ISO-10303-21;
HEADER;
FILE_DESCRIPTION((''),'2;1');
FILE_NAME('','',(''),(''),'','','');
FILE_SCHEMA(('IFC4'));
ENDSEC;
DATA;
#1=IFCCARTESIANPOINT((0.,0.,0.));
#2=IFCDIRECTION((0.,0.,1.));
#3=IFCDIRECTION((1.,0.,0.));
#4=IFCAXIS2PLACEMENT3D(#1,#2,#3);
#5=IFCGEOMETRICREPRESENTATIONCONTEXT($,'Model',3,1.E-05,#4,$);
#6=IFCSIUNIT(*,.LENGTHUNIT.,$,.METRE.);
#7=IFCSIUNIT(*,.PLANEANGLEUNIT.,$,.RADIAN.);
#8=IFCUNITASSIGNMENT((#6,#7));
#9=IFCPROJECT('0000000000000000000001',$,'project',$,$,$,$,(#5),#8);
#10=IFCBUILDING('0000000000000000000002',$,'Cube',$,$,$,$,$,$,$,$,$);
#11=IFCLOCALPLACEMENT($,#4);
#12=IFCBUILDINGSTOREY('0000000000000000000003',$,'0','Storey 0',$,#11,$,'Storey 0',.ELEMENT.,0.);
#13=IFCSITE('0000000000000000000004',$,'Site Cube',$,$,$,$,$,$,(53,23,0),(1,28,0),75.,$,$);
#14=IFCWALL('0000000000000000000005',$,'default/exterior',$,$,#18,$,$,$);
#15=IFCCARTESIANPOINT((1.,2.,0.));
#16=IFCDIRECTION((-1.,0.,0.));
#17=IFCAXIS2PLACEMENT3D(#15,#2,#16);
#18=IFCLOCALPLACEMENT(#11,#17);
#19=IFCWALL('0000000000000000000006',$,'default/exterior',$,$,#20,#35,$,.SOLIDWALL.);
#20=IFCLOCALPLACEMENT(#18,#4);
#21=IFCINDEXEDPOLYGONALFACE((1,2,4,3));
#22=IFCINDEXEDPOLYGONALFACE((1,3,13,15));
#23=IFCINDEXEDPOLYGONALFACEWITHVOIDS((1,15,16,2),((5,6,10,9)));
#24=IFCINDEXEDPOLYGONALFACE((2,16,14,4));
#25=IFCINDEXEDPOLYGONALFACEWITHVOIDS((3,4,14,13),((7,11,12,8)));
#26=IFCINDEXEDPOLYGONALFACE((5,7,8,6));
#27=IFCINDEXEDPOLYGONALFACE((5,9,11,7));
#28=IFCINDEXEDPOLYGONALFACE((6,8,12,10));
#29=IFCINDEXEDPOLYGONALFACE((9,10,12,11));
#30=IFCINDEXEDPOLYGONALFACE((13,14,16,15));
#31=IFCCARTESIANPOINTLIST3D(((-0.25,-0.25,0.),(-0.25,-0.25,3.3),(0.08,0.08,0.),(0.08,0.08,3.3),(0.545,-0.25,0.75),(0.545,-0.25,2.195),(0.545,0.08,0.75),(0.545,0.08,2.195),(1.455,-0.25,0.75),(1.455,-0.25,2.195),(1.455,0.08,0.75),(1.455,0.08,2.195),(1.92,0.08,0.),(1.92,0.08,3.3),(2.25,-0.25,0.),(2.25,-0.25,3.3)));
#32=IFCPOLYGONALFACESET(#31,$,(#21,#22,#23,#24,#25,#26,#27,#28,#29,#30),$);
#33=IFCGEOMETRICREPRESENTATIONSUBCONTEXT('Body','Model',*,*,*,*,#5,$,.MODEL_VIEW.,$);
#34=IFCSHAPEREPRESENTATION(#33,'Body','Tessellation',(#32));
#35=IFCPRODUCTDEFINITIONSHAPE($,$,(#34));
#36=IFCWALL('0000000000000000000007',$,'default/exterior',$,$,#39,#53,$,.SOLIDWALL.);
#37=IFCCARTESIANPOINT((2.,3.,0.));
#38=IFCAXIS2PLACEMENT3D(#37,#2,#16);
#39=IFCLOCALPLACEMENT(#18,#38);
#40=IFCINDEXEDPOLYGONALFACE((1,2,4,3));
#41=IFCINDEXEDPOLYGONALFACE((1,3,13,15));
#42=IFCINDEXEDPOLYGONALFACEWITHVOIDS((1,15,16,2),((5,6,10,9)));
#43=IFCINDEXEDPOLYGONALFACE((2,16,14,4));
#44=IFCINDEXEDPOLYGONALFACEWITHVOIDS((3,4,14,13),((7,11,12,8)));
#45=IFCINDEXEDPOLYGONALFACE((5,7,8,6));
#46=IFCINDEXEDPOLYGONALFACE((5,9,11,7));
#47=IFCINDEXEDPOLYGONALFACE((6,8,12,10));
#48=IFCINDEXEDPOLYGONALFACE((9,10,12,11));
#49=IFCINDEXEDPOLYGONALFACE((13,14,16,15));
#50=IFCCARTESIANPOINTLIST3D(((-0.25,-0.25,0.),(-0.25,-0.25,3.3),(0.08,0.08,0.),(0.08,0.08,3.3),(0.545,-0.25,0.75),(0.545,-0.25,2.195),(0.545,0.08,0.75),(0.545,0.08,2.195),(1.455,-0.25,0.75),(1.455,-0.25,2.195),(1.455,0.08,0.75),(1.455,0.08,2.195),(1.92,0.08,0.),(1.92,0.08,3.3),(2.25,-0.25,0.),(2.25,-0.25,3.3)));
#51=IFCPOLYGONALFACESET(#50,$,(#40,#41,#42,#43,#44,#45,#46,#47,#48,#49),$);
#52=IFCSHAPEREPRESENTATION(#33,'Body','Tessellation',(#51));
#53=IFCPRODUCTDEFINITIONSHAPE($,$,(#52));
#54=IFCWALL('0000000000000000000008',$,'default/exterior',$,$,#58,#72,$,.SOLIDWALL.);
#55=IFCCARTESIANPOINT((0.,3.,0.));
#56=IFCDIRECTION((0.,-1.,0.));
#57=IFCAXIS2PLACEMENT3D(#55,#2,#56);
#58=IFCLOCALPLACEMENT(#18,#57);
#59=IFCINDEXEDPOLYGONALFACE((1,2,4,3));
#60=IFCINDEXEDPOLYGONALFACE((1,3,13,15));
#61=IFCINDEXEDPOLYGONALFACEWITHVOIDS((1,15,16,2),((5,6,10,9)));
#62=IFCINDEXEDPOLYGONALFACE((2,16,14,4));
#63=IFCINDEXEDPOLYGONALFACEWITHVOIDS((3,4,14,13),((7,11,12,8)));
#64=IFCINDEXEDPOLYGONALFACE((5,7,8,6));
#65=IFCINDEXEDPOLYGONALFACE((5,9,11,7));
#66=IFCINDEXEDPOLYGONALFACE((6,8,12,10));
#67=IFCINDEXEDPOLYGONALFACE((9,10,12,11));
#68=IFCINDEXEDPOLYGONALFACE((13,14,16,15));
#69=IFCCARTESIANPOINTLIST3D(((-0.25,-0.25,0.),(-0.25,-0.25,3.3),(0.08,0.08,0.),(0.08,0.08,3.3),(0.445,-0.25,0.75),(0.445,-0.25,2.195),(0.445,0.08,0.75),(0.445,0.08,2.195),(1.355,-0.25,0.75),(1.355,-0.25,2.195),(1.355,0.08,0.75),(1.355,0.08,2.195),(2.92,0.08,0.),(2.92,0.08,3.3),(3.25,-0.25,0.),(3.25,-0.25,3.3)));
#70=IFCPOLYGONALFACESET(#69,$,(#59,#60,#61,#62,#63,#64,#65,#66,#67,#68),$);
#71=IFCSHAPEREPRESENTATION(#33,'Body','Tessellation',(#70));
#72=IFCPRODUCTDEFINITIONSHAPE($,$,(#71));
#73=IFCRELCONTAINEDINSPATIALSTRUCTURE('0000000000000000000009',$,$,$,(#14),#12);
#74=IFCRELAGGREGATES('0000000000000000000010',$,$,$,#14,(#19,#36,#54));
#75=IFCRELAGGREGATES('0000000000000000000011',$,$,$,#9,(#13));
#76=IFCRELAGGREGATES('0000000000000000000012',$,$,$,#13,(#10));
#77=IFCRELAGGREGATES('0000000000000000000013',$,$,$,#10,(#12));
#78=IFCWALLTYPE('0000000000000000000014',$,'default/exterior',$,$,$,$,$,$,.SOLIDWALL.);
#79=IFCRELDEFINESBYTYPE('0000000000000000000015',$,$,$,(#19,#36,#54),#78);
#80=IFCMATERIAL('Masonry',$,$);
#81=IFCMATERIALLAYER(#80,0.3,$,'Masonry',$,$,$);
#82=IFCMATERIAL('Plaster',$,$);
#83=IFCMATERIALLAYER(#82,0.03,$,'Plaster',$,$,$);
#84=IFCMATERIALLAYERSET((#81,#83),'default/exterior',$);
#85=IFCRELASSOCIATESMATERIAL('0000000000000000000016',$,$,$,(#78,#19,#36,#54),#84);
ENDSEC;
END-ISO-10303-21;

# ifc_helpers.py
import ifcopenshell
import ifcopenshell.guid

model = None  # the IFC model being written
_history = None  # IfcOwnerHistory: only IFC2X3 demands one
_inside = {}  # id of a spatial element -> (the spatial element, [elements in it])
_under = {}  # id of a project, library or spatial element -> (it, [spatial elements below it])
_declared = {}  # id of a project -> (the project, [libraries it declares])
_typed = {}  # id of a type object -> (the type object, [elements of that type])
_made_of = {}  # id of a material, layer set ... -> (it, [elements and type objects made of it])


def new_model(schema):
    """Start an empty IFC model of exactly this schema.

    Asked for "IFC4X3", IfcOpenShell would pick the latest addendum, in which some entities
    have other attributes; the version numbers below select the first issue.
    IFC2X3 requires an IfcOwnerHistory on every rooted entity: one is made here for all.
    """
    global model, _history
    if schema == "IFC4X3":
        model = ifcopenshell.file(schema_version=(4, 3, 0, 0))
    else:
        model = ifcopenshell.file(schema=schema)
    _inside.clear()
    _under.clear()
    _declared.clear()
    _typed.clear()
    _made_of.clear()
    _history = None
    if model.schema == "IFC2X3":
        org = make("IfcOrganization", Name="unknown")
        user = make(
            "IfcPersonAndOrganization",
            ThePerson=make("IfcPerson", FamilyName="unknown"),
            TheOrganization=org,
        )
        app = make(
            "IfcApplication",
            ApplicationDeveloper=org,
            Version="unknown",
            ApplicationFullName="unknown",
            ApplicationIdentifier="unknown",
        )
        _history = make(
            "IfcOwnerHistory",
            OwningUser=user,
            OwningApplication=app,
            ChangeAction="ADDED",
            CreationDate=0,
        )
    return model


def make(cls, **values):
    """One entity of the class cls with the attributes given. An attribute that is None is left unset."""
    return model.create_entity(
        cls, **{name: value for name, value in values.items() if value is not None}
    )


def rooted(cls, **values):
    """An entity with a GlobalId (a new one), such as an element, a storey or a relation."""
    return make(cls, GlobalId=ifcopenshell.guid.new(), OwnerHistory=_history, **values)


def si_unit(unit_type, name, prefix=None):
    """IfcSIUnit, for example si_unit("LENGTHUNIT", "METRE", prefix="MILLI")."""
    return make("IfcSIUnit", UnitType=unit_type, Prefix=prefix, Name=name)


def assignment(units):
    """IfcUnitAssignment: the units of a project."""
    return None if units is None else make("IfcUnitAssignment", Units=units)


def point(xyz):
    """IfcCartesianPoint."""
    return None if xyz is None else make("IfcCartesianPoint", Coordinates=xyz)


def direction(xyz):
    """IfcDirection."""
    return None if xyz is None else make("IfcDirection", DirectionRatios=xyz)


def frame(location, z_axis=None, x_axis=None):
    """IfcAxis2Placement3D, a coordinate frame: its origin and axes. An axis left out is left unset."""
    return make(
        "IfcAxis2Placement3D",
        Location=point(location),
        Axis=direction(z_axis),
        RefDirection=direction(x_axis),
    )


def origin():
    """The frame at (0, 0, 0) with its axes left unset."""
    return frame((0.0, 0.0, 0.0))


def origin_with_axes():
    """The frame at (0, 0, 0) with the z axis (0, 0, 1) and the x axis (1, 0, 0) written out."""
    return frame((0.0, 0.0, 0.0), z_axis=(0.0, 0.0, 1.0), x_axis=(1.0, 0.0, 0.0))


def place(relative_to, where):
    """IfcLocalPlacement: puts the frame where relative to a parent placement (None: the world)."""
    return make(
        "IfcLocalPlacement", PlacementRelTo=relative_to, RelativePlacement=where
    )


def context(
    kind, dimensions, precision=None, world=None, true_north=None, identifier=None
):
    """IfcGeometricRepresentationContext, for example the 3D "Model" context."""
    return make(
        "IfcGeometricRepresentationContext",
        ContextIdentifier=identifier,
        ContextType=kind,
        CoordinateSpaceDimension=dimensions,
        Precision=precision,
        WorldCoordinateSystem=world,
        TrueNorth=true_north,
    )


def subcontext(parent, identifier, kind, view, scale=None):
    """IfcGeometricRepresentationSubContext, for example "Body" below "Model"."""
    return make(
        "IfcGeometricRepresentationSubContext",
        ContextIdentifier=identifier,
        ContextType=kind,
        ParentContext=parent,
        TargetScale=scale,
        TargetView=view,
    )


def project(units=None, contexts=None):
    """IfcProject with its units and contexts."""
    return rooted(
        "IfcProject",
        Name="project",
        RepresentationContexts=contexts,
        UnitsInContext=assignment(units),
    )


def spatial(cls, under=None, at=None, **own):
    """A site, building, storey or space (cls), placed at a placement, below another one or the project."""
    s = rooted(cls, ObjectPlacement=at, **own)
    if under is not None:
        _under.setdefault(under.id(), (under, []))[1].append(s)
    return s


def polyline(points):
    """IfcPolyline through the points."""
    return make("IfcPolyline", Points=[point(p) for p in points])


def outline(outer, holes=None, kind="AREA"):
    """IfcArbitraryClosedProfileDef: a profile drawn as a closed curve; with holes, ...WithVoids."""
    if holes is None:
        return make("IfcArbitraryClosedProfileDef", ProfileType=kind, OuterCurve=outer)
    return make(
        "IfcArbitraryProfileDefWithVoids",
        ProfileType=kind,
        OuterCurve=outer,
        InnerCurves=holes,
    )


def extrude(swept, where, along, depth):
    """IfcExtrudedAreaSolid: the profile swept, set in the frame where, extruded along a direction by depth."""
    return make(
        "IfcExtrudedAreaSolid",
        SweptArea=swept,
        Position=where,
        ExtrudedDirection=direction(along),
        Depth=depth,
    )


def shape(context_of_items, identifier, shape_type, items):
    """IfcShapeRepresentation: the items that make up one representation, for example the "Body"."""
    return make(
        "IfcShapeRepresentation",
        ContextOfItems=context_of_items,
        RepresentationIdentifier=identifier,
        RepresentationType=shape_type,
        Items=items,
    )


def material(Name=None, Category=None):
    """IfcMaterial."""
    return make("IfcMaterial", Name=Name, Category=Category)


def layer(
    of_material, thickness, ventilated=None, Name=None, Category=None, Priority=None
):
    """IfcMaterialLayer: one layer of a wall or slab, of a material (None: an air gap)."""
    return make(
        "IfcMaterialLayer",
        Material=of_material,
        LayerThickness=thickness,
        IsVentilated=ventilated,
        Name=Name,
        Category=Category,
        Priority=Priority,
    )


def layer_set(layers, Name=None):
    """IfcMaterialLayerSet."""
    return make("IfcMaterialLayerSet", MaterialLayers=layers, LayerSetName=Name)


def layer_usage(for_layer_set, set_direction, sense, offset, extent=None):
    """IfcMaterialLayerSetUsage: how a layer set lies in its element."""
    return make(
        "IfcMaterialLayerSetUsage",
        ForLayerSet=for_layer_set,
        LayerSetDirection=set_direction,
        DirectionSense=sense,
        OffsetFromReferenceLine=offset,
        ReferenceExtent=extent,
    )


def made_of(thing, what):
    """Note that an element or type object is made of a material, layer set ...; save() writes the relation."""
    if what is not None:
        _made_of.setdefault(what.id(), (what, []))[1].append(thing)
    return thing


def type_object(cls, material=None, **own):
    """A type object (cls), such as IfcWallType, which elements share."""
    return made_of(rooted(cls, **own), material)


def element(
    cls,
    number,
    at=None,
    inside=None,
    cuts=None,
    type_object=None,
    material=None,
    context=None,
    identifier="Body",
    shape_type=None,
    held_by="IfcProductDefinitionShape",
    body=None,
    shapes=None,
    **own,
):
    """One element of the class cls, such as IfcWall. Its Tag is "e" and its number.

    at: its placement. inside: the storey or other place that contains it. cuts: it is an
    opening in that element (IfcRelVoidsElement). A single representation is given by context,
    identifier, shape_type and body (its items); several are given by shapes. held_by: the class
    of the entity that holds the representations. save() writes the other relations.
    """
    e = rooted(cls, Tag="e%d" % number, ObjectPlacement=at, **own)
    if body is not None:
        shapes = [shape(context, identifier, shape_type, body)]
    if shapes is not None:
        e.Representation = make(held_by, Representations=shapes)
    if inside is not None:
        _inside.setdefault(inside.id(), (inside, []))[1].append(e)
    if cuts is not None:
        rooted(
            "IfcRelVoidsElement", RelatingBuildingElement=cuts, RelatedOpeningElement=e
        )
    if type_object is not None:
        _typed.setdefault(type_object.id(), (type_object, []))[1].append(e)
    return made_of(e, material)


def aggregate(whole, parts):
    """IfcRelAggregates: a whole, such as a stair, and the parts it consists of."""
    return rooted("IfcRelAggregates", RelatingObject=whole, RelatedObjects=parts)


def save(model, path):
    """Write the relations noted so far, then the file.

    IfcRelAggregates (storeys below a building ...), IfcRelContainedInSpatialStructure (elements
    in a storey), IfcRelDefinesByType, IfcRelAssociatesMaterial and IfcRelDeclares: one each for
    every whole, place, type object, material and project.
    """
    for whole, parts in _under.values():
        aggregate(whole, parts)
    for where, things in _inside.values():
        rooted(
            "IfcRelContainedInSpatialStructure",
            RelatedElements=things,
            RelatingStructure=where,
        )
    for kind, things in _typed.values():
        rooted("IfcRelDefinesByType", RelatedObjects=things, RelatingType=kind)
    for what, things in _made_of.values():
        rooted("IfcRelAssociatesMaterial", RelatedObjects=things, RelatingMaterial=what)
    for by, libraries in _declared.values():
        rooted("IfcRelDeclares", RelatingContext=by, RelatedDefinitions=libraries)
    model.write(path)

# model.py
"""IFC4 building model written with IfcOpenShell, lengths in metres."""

from ifc_helpers import new_model, si_unit, frame, origin, origin_with_axes, place, context, subcontext, project, spatial, polyline, outline, extrude, material, layer, layer_set, layer_usage, type_object, element, aggregate, save


model = new_model("IFC4")

# Units and contexts
model_context = context("Model", 3, precision=1e-05, world=origin_with_axes())
body_context = subcontext(model_context, "Body", "Model", "MODEL_VIEW")
ifc_project = project(units=[si_unit("LENGTHUNIT", "METRE"), si_unit("PLANEANGLEUNIT", "RADIAN")], contexts=[model_context])

# Site, building, storey
site = spatial("IfcSite", under=ifc_project, Name="Site Cube", RefLatitude=(53, 23, 0), RefLongitude=(1, 28, 0), RefElevation=75.0)
building = spatial("IfcBuilding", under=site, Name="Cube")
storey_placement = place(None, origin_with_axes())
storey = spatial("IfcBuildingStorey", under=building, at=storey_placement, Name="0", Description="Storey 0", LongName="Storey 0", CompositionType="ELEMENT", Elevation=0.0)

# Walls, openings
wall_1_placement = place(storey_placement, frame((1.0, 2.0, 0.0), z_axis=(0.0, 0.0, 1.0), x_axis=(-1.0, 0.0, 0.0)))
wall_1 = element("IfcWall", 1, at=wall_1_placement, inside=storey, Name="default/exterior")
ifc_material_1 = material(Name="Masonry")
ifc_layer_1 = layer(ifc_material_1, 0.3, Name="Masonry")
ifc_material_2 = material(Name="Plaster")
ifc_layer_2 = layer(ifc_material_2, 0.03, Name="Plaster")
ifc_layer_set_1 = layer_set([ifc_layer_1, ifc_layer_2], Name="default/exterior")
ifc_layer_usage_1 = layer_usage(ifc_layer_set_1, "AXIS2", "POSITIVE", -0.25)
wall_type = type_object("IfcWallType", Name="default/exterior", PredefinedType="SOLIDWALL", material=ifc_layer_set_1)
wall_2_placement = place(wall_1_placement, origin_with_axes())
wall_2 = element("IfcWall", 2, at=wall_2_placement, type_object=wall_type, material=ifc_layer_usage_1, Name="default/exterior", PredefinedType="SOLIDWALL", context=body_context, shape_type="SweptSolid", body=[
    extrude(outline(polyline([(0.08, 0.08), (-0.25, -0.25), (2.25, -0.25), (1.92, 0.08), (0.08, 0.08)])), origin(), (0.0, 0.0, 1.0), 3.3),
])
opening_1_placement = place(None, frame((0.455, 2.25, 0.75), z_axis=(0.0, 0.0, 1.0), x_axis=(-1.0, 0.0, 0.0)))
element("IfcOpeningElement", 3, at=opening_1_placement, cuts=wall_2, PredefinedType="OPENING", context=body_context, shape_type="SweptSolid", body=[
    extrude(outline(polyline([(0.0, -0.02), (0.91, -0.02), (0.91, 0.35), (0.0, 0.35), (0.0, -0.02)])), origin(), (0.0, 0.0, 1.0), 1.445),
])
ifc_layer_usage_2 = layer_usage(ifc_layer_set_1, "AXIS2", "POSITIVE", -0.25)
wall_3_placement = place(wall_1_placement, frame((2.0, 3.0, 0.0), z_axis=(0.0, 0.0, 1.0), x_axis=(-1.0, 0.0, 0.0)))
wall_3 = element("IfcWall", 4, at=wall_3_placement, type_object=wall_type, material=ifc_layer_usage_2, Name="default/exterior", PredefinedType="SOLIDWALL", context=body_context, shape_type="SweptSolid", body=[
    extrude(outline(polyline([(0.08, 0.08), (-0.25, -0.25), (2.25, -0.25), (1.92, 0.08), (0.08, 0.08)])), origin(), (0.0, 0.0, 1.0), 3.3),
])
opening_2_placement = place(None, frame((-0.455, -1.25, 0.75), z_axis=(0.0, 0.0, 1.0), x_axis=(1.0, 0.0, 0.0)))
element("IfcOpeningElement", 5, at=opening_2_placement, cuts=wall_3, PredefinedType="OPENING", context=body_context, shape_type="SweptSolid", body=[
    extrude(outline(polyline([(0.0, -0.02), (0.91, -0.02), (0.91, 0.35), (0.0, 0.35), (0.0, -0.02)])), origin(), (0.0, 0.0, 1.0), 1.445),
])
ifc_layer_usage_3 = layer_usage(ifc_layer_set_1, "AXIS2", "POSITIVE", -0.25)
wall_4_placement = place(wall_1_placement, frame((0.0, 3.0, 0.0), z_axis=(0.0, 0.0, 1.0), x_axis=(0.0, -1.0, 0.0)))
wall_4 = element("IfcWall", 6, at=wall_4_placement, type_object=wall_type, material=ifc_layer_usage_3, Name="default/exterior", PredefinedType="SOLIDWALL", context=body_context, shape_type="SweptSolid", body=[
    extrude(outline(polyline([(0.08, 0.08), (-0.25, -0.25), (3.25, -0.25), (2.92, 0.08), (0.08, 0.08)])), origin(), (0.0, 0.0, 1.0), 3.3),
])
opening_3_placement = place(wall_4_placement, frame((0.445, -0.25, 0.75), z_axis=(0.0, 0.0, 1.0), x_axis=(1.0, 0.0, 0.0)))
element("IfcOpeningElement", 7, at=opening_3_placement, cuts=wall_4, PredefinedType="OPENING", context=body_context, shape_type="SweptSolid", body=[
    extrude(outline(polyline([(0.0, -0.02), (0.91, -0.02), (0.91, 0.35), (0.0, 0.35), (0.0, -0.02)])), origin(), (0.0, 0.0, 1.0), 1.445),
])
aggregate(wall_1, [wall_2, wall_3, wall_4])

save(model, "model.ifc")
